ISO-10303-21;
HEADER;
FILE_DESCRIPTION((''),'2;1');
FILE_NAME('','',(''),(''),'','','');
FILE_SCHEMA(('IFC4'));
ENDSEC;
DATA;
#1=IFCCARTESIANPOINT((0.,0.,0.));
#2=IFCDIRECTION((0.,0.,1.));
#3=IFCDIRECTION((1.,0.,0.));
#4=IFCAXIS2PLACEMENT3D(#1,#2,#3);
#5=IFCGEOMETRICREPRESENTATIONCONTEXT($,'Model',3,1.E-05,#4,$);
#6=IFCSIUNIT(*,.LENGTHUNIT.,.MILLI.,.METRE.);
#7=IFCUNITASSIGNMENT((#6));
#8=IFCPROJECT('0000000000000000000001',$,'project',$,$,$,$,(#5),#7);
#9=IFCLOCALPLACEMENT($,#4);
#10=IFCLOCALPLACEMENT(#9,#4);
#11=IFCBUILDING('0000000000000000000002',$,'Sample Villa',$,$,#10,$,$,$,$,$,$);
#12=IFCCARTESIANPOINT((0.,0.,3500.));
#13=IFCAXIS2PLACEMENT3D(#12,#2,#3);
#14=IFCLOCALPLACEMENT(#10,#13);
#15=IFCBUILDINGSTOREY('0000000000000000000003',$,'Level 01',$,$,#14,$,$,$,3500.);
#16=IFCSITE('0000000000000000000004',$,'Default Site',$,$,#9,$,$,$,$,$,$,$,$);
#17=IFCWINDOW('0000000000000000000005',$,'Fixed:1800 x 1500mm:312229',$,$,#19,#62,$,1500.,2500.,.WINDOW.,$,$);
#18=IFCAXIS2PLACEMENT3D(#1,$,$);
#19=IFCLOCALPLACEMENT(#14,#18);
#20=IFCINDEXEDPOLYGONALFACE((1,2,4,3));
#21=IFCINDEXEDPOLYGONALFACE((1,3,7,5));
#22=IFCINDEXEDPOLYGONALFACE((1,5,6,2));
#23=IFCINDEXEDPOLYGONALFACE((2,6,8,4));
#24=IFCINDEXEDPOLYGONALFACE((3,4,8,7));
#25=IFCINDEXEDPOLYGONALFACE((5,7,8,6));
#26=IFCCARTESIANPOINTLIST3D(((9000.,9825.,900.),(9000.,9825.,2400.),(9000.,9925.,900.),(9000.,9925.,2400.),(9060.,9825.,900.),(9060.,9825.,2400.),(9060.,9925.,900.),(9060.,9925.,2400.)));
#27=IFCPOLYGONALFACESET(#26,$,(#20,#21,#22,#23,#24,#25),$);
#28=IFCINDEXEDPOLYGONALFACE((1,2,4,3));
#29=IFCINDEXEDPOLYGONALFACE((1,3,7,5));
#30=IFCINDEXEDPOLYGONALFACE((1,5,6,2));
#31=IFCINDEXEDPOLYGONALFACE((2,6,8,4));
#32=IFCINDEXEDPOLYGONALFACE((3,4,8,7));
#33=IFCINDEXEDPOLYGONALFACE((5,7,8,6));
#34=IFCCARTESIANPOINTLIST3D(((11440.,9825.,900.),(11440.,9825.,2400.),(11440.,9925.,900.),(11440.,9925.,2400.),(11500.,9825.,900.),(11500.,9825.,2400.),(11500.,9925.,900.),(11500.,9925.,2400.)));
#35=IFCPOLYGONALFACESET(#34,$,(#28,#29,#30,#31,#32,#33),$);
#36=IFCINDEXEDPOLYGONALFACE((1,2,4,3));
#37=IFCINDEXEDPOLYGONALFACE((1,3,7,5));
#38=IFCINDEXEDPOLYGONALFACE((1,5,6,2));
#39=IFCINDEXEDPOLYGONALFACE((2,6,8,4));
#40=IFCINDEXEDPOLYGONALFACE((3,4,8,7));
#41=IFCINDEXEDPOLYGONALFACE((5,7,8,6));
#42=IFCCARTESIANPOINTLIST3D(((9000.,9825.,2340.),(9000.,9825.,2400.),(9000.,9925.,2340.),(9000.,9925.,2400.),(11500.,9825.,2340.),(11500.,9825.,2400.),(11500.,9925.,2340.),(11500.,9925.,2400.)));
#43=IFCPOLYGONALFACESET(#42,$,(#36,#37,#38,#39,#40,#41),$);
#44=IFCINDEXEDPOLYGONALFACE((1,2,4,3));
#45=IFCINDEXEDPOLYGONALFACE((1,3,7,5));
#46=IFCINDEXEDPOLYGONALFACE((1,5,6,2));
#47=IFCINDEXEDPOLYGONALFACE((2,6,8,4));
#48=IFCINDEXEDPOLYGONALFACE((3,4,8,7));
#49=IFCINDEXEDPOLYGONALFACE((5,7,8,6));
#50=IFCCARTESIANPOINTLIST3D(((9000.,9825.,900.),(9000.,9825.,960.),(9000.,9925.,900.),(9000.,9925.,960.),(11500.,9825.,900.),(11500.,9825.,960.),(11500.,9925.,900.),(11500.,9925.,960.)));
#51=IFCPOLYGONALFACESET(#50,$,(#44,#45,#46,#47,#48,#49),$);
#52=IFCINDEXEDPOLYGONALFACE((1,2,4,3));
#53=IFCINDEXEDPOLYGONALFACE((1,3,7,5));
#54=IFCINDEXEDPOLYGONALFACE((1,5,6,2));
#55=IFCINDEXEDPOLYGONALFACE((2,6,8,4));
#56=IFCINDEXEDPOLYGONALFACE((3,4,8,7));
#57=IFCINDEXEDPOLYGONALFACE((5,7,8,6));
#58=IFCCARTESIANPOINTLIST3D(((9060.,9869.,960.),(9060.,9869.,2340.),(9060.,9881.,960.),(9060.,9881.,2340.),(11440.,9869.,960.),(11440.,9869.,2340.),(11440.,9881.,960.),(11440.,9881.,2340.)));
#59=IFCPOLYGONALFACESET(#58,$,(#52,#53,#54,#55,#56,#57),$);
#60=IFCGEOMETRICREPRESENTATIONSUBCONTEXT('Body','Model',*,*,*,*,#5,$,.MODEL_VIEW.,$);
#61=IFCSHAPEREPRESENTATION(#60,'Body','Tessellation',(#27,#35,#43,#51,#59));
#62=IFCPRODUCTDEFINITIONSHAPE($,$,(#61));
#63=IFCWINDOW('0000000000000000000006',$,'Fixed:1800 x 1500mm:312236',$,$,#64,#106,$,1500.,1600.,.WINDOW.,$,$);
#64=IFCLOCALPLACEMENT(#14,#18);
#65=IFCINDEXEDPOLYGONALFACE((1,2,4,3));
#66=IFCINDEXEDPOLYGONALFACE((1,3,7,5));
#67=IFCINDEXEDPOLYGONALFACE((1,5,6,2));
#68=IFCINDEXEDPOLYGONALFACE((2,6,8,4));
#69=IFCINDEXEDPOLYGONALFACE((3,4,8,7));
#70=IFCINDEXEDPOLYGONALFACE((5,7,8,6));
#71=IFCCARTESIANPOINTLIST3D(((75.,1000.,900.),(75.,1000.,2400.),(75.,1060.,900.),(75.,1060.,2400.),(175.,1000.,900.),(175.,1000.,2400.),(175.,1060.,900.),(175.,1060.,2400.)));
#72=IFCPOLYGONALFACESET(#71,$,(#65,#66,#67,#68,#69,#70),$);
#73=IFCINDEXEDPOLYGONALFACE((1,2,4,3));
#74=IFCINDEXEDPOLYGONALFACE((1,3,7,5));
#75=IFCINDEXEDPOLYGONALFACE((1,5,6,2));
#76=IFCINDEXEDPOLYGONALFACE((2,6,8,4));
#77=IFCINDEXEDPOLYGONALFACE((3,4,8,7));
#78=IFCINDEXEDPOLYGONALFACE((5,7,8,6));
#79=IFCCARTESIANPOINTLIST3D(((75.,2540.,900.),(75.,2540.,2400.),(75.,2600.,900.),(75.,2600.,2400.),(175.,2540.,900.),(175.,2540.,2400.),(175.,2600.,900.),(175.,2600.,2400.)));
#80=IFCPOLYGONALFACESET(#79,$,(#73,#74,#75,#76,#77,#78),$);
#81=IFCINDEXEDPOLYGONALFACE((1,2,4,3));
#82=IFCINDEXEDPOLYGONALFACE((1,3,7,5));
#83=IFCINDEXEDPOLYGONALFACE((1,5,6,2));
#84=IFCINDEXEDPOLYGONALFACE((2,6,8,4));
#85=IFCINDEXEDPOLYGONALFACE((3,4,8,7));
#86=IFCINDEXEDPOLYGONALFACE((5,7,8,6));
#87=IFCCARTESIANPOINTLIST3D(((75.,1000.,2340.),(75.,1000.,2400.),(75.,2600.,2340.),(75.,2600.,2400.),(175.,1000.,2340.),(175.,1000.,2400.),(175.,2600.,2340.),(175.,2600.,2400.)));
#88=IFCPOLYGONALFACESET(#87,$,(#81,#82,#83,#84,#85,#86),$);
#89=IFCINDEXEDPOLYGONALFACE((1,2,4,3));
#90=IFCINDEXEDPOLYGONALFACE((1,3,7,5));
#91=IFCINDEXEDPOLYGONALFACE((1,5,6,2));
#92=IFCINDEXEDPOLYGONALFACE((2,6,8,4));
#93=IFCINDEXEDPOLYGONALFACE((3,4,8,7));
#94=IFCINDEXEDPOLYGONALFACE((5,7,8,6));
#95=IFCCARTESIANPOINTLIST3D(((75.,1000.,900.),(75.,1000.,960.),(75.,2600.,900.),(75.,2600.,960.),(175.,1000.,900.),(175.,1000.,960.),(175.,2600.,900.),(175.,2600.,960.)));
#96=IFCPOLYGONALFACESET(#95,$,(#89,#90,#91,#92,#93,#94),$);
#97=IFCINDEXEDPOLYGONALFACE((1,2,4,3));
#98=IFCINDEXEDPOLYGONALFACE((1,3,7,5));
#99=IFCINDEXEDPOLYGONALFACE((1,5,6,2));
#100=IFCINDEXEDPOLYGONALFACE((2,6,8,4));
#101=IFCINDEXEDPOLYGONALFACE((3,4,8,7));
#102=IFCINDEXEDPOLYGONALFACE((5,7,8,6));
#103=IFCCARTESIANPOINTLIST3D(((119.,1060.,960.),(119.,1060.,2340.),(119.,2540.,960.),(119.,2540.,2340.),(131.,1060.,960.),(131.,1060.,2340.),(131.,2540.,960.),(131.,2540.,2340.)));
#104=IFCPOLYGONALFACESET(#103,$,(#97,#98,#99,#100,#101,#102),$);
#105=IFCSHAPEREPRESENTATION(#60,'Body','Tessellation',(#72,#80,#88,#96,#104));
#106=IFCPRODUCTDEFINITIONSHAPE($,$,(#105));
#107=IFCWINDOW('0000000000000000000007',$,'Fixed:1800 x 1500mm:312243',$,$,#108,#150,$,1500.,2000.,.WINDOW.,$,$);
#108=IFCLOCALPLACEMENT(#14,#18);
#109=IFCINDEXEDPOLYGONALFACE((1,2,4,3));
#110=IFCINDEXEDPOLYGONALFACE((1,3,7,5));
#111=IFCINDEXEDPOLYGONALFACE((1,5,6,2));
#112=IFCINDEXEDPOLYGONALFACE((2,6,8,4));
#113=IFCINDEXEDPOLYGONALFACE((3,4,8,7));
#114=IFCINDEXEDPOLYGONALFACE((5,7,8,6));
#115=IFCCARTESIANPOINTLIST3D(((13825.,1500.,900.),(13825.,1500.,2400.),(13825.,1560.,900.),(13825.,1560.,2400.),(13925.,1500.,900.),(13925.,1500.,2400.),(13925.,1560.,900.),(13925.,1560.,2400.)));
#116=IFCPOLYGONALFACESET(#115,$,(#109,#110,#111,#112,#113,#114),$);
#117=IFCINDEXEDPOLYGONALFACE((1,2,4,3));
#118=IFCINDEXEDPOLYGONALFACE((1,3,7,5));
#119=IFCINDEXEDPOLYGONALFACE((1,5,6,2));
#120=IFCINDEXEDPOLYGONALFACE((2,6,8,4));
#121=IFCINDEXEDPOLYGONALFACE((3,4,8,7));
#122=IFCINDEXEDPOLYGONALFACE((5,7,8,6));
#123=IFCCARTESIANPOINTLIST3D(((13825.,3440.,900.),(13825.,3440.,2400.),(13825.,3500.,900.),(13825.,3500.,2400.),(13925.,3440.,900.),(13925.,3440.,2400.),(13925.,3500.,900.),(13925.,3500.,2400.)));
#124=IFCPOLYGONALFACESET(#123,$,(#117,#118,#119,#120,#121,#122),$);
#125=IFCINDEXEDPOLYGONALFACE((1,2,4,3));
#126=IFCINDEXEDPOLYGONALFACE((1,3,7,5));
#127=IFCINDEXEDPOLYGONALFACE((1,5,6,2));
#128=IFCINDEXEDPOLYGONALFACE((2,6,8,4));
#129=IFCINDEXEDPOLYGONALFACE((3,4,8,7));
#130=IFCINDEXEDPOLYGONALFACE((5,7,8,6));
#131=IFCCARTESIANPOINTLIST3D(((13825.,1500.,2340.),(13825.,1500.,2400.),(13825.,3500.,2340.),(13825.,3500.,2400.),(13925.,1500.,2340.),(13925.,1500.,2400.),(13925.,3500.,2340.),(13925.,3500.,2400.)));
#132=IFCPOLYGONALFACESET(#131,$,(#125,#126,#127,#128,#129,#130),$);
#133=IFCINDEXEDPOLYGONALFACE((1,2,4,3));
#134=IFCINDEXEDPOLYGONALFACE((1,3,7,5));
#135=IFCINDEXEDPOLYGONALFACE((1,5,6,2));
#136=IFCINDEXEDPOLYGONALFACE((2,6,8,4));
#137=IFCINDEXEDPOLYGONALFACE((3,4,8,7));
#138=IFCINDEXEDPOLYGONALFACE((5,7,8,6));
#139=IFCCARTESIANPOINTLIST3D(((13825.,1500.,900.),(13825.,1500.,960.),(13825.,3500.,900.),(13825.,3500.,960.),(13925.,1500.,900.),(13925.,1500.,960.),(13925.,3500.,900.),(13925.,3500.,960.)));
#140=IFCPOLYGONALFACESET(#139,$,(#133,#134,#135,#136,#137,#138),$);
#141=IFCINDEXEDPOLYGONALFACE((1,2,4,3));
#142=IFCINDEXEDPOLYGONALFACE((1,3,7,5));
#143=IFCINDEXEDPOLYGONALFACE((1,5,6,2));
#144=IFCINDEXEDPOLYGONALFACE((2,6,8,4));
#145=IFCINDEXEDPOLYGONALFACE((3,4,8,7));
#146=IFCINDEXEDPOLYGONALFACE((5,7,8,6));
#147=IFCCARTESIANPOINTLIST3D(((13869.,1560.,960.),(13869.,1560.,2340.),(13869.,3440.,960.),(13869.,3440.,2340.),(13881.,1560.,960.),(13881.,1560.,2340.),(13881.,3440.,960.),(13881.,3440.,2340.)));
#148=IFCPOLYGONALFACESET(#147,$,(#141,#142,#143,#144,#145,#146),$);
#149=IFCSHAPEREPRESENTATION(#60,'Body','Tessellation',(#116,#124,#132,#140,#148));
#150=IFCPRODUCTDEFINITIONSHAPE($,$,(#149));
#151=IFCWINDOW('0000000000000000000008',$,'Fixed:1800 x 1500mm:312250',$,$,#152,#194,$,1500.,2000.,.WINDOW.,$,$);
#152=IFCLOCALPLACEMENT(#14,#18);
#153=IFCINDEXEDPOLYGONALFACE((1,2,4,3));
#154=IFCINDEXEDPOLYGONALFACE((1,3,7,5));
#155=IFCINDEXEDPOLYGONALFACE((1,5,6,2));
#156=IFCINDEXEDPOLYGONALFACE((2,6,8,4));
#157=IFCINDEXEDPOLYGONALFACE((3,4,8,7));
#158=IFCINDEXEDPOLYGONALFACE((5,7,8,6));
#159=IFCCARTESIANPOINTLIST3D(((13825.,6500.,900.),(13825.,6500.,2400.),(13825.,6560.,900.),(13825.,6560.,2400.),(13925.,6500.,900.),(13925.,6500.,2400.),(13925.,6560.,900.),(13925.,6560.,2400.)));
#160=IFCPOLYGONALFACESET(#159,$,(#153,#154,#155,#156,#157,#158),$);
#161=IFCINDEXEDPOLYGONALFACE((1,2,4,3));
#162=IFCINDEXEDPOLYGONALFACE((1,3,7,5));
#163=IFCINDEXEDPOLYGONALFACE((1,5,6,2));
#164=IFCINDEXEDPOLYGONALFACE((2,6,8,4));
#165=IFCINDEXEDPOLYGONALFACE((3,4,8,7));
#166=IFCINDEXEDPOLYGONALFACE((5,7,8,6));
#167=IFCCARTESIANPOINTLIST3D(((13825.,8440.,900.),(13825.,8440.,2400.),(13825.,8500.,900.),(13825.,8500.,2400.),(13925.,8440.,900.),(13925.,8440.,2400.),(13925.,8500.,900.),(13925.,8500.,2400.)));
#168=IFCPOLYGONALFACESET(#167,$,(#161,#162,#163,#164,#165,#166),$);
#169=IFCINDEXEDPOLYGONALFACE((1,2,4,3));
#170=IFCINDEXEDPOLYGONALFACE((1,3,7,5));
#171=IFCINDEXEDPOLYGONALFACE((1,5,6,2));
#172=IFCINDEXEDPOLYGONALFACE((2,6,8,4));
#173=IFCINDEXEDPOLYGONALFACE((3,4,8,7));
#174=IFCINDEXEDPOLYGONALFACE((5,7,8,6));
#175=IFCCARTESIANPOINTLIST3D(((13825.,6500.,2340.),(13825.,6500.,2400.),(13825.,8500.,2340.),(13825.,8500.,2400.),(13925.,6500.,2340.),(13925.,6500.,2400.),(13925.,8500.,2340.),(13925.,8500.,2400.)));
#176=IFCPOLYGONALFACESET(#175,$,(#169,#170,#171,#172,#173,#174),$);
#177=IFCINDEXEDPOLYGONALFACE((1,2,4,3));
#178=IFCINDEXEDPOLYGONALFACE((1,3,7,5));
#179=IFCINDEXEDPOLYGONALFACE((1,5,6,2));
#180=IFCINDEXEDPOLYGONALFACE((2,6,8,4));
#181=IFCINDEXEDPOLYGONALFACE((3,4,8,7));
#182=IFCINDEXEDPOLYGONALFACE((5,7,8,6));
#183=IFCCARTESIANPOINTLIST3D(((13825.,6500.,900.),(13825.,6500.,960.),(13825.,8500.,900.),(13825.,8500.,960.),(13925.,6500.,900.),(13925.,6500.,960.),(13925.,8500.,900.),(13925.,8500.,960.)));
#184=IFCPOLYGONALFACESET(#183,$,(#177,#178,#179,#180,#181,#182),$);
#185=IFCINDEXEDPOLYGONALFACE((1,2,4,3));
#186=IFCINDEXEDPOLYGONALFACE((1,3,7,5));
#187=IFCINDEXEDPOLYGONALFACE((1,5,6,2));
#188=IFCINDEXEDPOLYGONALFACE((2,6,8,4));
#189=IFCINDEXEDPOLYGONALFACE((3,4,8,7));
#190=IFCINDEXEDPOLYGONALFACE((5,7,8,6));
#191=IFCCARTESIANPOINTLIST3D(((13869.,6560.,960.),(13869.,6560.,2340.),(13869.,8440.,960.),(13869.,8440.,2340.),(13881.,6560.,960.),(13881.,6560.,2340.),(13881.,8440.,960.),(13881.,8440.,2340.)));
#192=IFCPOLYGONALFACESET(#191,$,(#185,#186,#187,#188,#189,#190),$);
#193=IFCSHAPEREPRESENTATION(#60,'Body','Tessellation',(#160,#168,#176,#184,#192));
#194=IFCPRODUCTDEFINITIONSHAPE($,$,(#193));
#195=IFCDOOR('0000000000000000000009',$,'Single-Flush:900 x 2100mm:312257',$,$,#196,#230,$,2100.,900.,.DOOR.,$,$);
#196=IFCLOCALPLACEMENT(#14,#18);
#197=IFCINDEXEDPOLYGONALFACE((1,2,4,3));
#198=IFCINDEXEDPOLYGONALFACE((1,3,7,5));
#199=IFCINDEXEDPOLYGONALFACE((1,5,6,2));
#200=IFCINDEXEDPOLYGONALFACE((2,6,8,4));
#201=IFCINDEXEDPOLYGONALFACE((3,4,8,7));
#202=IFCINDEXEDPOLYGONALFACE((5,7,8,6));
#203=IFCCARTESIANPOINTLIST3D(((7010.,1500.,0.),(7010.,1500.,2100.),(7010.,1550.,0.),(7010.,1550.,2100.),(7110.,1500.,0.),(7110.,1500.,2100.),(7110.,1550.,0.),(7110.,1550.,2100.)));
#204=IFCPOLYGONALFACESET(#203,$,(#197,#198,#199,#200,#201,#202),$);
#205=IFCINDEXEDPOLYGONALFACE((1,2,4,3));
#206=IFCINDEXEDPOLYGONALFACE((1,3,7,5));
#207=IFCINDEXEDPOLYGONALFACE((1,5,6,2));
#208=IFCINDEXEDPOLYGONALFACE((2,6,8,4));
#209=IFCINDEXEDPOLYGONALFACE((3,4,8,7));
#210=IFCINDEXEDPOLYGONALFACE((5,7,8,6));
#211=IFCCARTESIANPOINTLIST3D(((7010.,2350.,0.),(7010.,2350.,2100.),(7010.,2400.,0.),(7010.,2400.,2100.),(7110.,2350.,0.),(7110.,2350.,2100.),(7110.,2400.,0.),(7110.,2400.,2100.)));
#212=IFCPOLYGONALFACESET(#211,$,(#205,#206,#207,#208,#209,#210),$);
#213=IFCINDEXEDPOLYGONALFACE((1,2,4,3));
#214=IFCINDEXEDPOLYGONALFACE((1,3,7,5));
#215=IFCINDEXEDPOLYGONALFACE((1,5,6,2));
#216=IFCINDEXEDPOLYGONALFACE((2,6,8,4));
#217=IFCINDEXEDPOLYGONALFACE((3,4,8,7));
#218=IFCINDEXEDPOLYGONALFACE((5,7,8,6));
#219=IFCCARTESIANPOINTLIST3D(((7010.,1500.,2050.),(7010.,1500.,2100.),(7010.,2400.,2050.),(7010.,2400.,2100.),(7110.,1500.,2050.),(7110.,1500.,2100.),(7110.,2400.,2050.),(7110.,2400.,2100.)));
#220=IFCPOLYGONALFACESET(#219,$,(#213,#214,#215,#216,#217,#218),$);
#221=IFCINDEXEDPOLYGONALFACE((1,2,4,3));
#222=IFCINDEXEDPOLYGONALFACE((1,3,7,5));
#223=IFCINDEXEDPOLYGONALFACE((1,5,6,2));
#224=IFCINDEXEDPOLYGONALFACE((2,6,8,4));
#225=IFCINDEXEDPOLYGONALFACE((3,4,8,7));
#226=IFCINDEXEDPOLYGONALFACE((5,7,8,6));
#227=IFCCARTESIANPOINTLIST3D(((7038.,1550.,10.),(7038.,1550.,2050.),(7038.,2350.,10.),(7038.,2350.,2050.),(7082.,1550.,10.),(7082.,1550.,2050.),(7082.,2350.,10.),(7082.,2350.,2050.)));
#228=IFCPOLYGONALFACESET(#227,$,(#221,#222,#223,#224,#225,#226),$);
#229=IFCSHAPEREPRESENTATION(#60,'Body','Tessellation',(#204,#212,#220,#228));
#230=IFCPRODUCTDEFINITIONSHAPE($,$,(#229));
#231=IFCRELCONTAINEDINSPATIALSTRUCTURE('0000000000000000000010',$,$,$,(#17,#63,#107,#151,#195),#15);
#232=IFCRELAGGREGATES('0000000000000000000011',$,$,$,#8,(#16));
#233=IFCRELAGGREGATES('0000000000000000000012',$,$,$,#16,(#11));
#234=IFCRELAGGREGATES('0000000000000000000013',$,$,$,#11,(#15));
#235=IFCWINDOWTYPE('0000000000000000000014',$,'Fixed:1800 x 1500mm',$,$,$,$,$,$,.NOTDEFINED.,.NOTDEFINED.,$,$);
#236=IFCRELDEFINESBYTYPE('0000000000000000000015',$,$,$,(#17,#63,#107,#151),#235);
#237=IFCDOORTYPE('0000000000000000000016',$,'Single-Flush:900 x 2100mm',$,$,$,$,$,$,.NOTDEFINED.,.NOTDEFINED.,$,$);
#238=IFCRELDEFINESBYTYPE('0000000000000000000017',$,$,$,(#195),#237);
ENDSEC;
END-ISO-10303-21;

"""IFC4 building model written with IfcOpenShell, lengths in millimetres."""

from ifc_helpers import new_model, si_unit, frame, frame_2d, origin_with_axes, place, context, subcontext, project, spatial, rectangle, extrude, type_object, element, save


model = new_model("IFC4")

# Units and contexts
model_context = context("Model", 3, precision=1e-05, world=origin_with_axes())
body_context = subcontext(model_context, "Body", "Model", "MODEL_VIEW")
ifc_project = project(units=[si_unit("LENGTHUNIT", "METRE", prefix="MILLI")], contexts=[model_context])

# Site, building, storey
site_placement = place(None, origin_with_axes())
site = spatial("IfcSite", under=ifc_project, at=site_placement, Name="Default Site")
building_placement = place(site_placement, origin_with_axes())
building = spatial("IfcBuilding", under=site, at=building_placement, Name="Sample Villa")
storey_placement = place(building_placement, frame((0.0, 0.0, 3500.0), z_axis=(0.0, 0.0, 1.0), x_axis=(1.0, 0.0, 0.0)))
storey = spatial("IfcBuildingStorey", under=building, at=storey_placement, Name="Level 01", Elevation=3500.0)

# Windows
window_type = type_object("IfcWindowType", Name="Fixed:1800 x 1500mm", PartitioningType="NOTDEFINED", PredefinedType="NOTDEFINED")
window_1_placement = place(storey_placement, frame((0.0, 0.0, -3500.0), z_axis=(0.0, 0.0, 1.0), x_axis=(1.0, 0.0, 0.0)))
element("IfcWindow", 1, at=window_1_placement, inside=storey, type_object=window_type, Name="Fixed:1800 x 1500mm:312229", OverallHeight=1500.0, OverallWidth=2500.0, PredefinedType="WINDOW", context=body_context, shape_type="SweptSolid", body=[
    extrude(rectangle(XDim=60.0, YDim=100.0, at=frame_2d((30.0, 50.0))), frame((9000.0, 9825.0, 4400.0)), (0.0, 0.0, 1.0), 1500.0),
    extrude(rectangle(XDim=60.0, YDim=100.0, at=frame_2d((30.0, 50.0))), frame((11440.0, 9825.0, 4400.0)), (0.0, 0.0, 1.0), 1500.0),
    extrude(rectangle(XDim=2500.0, YDim=100.0, at=frame_2d((1250.0, 50.0))), frame((9000.0, 9825.0, 5840.0)), (0.0, 0.0, 1.0), 60.0),
    extrude(rectangle(XDim=2500.0, YDim=100.0, at=frame_2d((1250.0, 50.0))), frame((9000.0, 9825.0, 4400.0)), (0.0, 0.0, 1.0), 60.0),
    extrude(rectangle(XDim=2380.0, YDim=12.0, at=frame_2d((1190.0, 6.0))), frame((9060.0, 9869.0, 4460.0)), (0.0, 0.0, 1.0), 1380.0),
])
window_2_placement = place(storey_placement, frame((0.0, 0.0, -3500.0), z_axis=(0.0, 0.0, 1.0), x_axis=(1.0, 0.0, 0.0)))
element("IfcWindow", 2, at=window_2_placement, inside=storey, type_object=window_type, Name="Fixed:1800 x 1500mm:312236", OverallHeight=1500.0, OverallWidth=1600.0, PredefinedType="WINDOW", context=body_context, shape_type="SweptSolid", body=[
    extrude(rectangle(XDim=100.0, YDim=60.0, at=frame_2d((50.0, 30.0))), frame((75.0, 1000.0, 4400.0)), (0.0, 0.0, 1.0), 1500.0),
    extrude(rectangle(XDim=100.0, YDim=60.0, at=frame_2d((50.0, 30.0))), frame((75.0, 2540.0, 4400.0)), (0.0, 0.0, 1.0), 1500.0),
    extrude(rectangle(XDim=100.0, YDim=1600.0, at=frame_2d((50.0, 800.0))), frame((75.0, 1000.0, 5840.0)), (0.0, 0.0, 1.0), 60.0),
    extrude(rectangle(XDim=100.0, YDim=1600.0, at=frame_2d((50.0, 800.0))), frame((75.0, 1000.0, 4400.0)), (0.0, 0.0, 1.0), 60.0),
    extrude(rectangle(XDim=12.0, YDim=1480.0, at=frame_2d((6.0, 740.0))), frame((119.0, 1060.0, 4460.0)), (0.0, 0.0, 1.0), 1380.0),
])
window_3_placement = place(storey_placement, frame((0.0, 0.0, -3500.0), z_axis=(0.0, 0.0, 1.0), x_axis=(1.0, 0.0, 0.0)))
element("IfcWindow", 3, at=window_3_placement, inside=storey, type_object=window_type, Name="Fixed:1800 x 1500mm:312243", OverallHeight=1500.0, OverallWidth=2000.0, PredefinedType="WINDOW", context=body_context, shape_type="SweptSolid", body=[
    extrude(rectangle(XDim=100.0, YDim=60.0, at=frame_2d((50.0, 30.0))), frame((13825.0, 1500.0, 4400.0)), (0.0, 0.0, 1.0), 1500.0),
    extrude(rectangle(XDim=100.0, YDim=60.0, at=frame_2d((50.0, 30.0))), frame((13825.0, 3440.0, 4400.0)), (0.0, 0.0, 1.0), 1500.0),
    extrude(rectangle(XDim=100.0, YDim=2000.0, at=frame_2d((50.0, 1000.0))), frame((13825.0, 1500.0, 5840.0)), (0.0, 0.0, 1.0), 60.0),
    extrude(rectangle(XDim=100.0, YDim=2000.0, at=frame_2d((50.0, 1000.0))), frame((13825.0, 1500.0, 4400.0)), (0.0, 0.0, 1.0), 60.0),
    extrude(rectangle(XDim=12.0, YDim=1880.0, at=frame_2d((6.0, 940.0))), frame((13869.0, 1560.0, 4460.0)), (0.0, 0.0, 1.0), 1380.0),
])
window_4_placement = place(storey_placement, frame((0.0, 0.0, -3500.0), z_axis=(0.0, 0.0, 1.0), x_axis=(1.0, 0.0, 0.0)))
element("IfcWindow", 4, at=window_4_placement, inside=storey, type_object=window_type, Name="Fixed:1800 x 1500mm:312250", OverallHeight=1500.0, OverallWidth=2000.0, PredefinedType="WINDOW", context=body_context, shape_type="SweptSolid", body=[
    extrude(rectangle(XDim=100.0, YDim=60.0, at=frame_2d((50.0, 30.0))), frame((13825.0, 6500.0, 4400.0)), (0.0, 0.0, 1.0), 1500.0),
    extrude(rectangle(XDim=100.0, YDim=60.0, at=frame_2d((50.0, 30.0))), frame((13825.0, 8440.0, 4400.0)), (0.0, 0.0, 1.0), 1500.0),
    extrude(rectangle(XDim=100.0, YDim=2000.0, at=frame_2d((50.0, 1000.0))), frame((13825.0, 6500.0, 5840.0)), (0.0, 0.0, 1.0), 60.0),
    extrude(rectangle(XDim=100.0, YDim=2000.0, at=frame_2d((50.0, 1000.0))), frame((13825.0, 6500.0, 4400.0)), (0.0, 0.0, 1.0), 60.0),
    extrude(rectangle(XDim=12.0, YDim=1880.0, at=frame_2d((6.0, 940.0))), frame((13869.0, 6560.0, 4460.0)), (0.0, 0.0, 1.0), 1380.0),
])

# Door
door_type = type_object("IfcDoorType", Name="Single-Flush:900 x 2100mm", OperationType="NOTDEFINED", PredefinedType="NOTDEFINED")
door_1_placement = place(storey_placement, frame((0.0, 0.0, -3500.0), z_axis=(0.0, 0.0, 1.0), x_axis=(1.0, 0.0, 0.0)))
element("IfcDoor", 5, at=door_1_placement, inside=storey, type_object=door_type, Name="Single-Flush:900 x 2100mm:312257", OverallHeight=2100.0, OverallWidth=900.0, PredefinedType="DOOR", context=body_context, shape_type="SweptSolid", body=[
    extrude(rectangle(XDim=100.0, YDim=50.0, at=frame_2d((50.0, 25.0))), frame((7010.0, 1500.0, 3500.0)), (0.0, 0.0, 1.0), 2100.0),
    extrude(rectangle(XDim=100.0, YDim=50.0, at=frame_2d((50.0, 25.0))), frame((7010.0, 2350.0, 3500.0)), (0.0, 0.0, 1.0), 2100.0),
    extrude(rectangle(XDim=100.0, YDim=900.0, at=frame_2d((50.0, 450.0))), frame((7010.0, 1500.0, 5550.0)), (0.0, 0.0, 1.0), 50.0),
    extrude(rectangle(XDim=44.0, YDim=800.0, at=frame_2d((22.0, 400.0))), frame((7038.0, 1550.0, 3510.0)), (0.0, 0.0, 1.0), 2040.0),
])

save(model, "model.ifc")
